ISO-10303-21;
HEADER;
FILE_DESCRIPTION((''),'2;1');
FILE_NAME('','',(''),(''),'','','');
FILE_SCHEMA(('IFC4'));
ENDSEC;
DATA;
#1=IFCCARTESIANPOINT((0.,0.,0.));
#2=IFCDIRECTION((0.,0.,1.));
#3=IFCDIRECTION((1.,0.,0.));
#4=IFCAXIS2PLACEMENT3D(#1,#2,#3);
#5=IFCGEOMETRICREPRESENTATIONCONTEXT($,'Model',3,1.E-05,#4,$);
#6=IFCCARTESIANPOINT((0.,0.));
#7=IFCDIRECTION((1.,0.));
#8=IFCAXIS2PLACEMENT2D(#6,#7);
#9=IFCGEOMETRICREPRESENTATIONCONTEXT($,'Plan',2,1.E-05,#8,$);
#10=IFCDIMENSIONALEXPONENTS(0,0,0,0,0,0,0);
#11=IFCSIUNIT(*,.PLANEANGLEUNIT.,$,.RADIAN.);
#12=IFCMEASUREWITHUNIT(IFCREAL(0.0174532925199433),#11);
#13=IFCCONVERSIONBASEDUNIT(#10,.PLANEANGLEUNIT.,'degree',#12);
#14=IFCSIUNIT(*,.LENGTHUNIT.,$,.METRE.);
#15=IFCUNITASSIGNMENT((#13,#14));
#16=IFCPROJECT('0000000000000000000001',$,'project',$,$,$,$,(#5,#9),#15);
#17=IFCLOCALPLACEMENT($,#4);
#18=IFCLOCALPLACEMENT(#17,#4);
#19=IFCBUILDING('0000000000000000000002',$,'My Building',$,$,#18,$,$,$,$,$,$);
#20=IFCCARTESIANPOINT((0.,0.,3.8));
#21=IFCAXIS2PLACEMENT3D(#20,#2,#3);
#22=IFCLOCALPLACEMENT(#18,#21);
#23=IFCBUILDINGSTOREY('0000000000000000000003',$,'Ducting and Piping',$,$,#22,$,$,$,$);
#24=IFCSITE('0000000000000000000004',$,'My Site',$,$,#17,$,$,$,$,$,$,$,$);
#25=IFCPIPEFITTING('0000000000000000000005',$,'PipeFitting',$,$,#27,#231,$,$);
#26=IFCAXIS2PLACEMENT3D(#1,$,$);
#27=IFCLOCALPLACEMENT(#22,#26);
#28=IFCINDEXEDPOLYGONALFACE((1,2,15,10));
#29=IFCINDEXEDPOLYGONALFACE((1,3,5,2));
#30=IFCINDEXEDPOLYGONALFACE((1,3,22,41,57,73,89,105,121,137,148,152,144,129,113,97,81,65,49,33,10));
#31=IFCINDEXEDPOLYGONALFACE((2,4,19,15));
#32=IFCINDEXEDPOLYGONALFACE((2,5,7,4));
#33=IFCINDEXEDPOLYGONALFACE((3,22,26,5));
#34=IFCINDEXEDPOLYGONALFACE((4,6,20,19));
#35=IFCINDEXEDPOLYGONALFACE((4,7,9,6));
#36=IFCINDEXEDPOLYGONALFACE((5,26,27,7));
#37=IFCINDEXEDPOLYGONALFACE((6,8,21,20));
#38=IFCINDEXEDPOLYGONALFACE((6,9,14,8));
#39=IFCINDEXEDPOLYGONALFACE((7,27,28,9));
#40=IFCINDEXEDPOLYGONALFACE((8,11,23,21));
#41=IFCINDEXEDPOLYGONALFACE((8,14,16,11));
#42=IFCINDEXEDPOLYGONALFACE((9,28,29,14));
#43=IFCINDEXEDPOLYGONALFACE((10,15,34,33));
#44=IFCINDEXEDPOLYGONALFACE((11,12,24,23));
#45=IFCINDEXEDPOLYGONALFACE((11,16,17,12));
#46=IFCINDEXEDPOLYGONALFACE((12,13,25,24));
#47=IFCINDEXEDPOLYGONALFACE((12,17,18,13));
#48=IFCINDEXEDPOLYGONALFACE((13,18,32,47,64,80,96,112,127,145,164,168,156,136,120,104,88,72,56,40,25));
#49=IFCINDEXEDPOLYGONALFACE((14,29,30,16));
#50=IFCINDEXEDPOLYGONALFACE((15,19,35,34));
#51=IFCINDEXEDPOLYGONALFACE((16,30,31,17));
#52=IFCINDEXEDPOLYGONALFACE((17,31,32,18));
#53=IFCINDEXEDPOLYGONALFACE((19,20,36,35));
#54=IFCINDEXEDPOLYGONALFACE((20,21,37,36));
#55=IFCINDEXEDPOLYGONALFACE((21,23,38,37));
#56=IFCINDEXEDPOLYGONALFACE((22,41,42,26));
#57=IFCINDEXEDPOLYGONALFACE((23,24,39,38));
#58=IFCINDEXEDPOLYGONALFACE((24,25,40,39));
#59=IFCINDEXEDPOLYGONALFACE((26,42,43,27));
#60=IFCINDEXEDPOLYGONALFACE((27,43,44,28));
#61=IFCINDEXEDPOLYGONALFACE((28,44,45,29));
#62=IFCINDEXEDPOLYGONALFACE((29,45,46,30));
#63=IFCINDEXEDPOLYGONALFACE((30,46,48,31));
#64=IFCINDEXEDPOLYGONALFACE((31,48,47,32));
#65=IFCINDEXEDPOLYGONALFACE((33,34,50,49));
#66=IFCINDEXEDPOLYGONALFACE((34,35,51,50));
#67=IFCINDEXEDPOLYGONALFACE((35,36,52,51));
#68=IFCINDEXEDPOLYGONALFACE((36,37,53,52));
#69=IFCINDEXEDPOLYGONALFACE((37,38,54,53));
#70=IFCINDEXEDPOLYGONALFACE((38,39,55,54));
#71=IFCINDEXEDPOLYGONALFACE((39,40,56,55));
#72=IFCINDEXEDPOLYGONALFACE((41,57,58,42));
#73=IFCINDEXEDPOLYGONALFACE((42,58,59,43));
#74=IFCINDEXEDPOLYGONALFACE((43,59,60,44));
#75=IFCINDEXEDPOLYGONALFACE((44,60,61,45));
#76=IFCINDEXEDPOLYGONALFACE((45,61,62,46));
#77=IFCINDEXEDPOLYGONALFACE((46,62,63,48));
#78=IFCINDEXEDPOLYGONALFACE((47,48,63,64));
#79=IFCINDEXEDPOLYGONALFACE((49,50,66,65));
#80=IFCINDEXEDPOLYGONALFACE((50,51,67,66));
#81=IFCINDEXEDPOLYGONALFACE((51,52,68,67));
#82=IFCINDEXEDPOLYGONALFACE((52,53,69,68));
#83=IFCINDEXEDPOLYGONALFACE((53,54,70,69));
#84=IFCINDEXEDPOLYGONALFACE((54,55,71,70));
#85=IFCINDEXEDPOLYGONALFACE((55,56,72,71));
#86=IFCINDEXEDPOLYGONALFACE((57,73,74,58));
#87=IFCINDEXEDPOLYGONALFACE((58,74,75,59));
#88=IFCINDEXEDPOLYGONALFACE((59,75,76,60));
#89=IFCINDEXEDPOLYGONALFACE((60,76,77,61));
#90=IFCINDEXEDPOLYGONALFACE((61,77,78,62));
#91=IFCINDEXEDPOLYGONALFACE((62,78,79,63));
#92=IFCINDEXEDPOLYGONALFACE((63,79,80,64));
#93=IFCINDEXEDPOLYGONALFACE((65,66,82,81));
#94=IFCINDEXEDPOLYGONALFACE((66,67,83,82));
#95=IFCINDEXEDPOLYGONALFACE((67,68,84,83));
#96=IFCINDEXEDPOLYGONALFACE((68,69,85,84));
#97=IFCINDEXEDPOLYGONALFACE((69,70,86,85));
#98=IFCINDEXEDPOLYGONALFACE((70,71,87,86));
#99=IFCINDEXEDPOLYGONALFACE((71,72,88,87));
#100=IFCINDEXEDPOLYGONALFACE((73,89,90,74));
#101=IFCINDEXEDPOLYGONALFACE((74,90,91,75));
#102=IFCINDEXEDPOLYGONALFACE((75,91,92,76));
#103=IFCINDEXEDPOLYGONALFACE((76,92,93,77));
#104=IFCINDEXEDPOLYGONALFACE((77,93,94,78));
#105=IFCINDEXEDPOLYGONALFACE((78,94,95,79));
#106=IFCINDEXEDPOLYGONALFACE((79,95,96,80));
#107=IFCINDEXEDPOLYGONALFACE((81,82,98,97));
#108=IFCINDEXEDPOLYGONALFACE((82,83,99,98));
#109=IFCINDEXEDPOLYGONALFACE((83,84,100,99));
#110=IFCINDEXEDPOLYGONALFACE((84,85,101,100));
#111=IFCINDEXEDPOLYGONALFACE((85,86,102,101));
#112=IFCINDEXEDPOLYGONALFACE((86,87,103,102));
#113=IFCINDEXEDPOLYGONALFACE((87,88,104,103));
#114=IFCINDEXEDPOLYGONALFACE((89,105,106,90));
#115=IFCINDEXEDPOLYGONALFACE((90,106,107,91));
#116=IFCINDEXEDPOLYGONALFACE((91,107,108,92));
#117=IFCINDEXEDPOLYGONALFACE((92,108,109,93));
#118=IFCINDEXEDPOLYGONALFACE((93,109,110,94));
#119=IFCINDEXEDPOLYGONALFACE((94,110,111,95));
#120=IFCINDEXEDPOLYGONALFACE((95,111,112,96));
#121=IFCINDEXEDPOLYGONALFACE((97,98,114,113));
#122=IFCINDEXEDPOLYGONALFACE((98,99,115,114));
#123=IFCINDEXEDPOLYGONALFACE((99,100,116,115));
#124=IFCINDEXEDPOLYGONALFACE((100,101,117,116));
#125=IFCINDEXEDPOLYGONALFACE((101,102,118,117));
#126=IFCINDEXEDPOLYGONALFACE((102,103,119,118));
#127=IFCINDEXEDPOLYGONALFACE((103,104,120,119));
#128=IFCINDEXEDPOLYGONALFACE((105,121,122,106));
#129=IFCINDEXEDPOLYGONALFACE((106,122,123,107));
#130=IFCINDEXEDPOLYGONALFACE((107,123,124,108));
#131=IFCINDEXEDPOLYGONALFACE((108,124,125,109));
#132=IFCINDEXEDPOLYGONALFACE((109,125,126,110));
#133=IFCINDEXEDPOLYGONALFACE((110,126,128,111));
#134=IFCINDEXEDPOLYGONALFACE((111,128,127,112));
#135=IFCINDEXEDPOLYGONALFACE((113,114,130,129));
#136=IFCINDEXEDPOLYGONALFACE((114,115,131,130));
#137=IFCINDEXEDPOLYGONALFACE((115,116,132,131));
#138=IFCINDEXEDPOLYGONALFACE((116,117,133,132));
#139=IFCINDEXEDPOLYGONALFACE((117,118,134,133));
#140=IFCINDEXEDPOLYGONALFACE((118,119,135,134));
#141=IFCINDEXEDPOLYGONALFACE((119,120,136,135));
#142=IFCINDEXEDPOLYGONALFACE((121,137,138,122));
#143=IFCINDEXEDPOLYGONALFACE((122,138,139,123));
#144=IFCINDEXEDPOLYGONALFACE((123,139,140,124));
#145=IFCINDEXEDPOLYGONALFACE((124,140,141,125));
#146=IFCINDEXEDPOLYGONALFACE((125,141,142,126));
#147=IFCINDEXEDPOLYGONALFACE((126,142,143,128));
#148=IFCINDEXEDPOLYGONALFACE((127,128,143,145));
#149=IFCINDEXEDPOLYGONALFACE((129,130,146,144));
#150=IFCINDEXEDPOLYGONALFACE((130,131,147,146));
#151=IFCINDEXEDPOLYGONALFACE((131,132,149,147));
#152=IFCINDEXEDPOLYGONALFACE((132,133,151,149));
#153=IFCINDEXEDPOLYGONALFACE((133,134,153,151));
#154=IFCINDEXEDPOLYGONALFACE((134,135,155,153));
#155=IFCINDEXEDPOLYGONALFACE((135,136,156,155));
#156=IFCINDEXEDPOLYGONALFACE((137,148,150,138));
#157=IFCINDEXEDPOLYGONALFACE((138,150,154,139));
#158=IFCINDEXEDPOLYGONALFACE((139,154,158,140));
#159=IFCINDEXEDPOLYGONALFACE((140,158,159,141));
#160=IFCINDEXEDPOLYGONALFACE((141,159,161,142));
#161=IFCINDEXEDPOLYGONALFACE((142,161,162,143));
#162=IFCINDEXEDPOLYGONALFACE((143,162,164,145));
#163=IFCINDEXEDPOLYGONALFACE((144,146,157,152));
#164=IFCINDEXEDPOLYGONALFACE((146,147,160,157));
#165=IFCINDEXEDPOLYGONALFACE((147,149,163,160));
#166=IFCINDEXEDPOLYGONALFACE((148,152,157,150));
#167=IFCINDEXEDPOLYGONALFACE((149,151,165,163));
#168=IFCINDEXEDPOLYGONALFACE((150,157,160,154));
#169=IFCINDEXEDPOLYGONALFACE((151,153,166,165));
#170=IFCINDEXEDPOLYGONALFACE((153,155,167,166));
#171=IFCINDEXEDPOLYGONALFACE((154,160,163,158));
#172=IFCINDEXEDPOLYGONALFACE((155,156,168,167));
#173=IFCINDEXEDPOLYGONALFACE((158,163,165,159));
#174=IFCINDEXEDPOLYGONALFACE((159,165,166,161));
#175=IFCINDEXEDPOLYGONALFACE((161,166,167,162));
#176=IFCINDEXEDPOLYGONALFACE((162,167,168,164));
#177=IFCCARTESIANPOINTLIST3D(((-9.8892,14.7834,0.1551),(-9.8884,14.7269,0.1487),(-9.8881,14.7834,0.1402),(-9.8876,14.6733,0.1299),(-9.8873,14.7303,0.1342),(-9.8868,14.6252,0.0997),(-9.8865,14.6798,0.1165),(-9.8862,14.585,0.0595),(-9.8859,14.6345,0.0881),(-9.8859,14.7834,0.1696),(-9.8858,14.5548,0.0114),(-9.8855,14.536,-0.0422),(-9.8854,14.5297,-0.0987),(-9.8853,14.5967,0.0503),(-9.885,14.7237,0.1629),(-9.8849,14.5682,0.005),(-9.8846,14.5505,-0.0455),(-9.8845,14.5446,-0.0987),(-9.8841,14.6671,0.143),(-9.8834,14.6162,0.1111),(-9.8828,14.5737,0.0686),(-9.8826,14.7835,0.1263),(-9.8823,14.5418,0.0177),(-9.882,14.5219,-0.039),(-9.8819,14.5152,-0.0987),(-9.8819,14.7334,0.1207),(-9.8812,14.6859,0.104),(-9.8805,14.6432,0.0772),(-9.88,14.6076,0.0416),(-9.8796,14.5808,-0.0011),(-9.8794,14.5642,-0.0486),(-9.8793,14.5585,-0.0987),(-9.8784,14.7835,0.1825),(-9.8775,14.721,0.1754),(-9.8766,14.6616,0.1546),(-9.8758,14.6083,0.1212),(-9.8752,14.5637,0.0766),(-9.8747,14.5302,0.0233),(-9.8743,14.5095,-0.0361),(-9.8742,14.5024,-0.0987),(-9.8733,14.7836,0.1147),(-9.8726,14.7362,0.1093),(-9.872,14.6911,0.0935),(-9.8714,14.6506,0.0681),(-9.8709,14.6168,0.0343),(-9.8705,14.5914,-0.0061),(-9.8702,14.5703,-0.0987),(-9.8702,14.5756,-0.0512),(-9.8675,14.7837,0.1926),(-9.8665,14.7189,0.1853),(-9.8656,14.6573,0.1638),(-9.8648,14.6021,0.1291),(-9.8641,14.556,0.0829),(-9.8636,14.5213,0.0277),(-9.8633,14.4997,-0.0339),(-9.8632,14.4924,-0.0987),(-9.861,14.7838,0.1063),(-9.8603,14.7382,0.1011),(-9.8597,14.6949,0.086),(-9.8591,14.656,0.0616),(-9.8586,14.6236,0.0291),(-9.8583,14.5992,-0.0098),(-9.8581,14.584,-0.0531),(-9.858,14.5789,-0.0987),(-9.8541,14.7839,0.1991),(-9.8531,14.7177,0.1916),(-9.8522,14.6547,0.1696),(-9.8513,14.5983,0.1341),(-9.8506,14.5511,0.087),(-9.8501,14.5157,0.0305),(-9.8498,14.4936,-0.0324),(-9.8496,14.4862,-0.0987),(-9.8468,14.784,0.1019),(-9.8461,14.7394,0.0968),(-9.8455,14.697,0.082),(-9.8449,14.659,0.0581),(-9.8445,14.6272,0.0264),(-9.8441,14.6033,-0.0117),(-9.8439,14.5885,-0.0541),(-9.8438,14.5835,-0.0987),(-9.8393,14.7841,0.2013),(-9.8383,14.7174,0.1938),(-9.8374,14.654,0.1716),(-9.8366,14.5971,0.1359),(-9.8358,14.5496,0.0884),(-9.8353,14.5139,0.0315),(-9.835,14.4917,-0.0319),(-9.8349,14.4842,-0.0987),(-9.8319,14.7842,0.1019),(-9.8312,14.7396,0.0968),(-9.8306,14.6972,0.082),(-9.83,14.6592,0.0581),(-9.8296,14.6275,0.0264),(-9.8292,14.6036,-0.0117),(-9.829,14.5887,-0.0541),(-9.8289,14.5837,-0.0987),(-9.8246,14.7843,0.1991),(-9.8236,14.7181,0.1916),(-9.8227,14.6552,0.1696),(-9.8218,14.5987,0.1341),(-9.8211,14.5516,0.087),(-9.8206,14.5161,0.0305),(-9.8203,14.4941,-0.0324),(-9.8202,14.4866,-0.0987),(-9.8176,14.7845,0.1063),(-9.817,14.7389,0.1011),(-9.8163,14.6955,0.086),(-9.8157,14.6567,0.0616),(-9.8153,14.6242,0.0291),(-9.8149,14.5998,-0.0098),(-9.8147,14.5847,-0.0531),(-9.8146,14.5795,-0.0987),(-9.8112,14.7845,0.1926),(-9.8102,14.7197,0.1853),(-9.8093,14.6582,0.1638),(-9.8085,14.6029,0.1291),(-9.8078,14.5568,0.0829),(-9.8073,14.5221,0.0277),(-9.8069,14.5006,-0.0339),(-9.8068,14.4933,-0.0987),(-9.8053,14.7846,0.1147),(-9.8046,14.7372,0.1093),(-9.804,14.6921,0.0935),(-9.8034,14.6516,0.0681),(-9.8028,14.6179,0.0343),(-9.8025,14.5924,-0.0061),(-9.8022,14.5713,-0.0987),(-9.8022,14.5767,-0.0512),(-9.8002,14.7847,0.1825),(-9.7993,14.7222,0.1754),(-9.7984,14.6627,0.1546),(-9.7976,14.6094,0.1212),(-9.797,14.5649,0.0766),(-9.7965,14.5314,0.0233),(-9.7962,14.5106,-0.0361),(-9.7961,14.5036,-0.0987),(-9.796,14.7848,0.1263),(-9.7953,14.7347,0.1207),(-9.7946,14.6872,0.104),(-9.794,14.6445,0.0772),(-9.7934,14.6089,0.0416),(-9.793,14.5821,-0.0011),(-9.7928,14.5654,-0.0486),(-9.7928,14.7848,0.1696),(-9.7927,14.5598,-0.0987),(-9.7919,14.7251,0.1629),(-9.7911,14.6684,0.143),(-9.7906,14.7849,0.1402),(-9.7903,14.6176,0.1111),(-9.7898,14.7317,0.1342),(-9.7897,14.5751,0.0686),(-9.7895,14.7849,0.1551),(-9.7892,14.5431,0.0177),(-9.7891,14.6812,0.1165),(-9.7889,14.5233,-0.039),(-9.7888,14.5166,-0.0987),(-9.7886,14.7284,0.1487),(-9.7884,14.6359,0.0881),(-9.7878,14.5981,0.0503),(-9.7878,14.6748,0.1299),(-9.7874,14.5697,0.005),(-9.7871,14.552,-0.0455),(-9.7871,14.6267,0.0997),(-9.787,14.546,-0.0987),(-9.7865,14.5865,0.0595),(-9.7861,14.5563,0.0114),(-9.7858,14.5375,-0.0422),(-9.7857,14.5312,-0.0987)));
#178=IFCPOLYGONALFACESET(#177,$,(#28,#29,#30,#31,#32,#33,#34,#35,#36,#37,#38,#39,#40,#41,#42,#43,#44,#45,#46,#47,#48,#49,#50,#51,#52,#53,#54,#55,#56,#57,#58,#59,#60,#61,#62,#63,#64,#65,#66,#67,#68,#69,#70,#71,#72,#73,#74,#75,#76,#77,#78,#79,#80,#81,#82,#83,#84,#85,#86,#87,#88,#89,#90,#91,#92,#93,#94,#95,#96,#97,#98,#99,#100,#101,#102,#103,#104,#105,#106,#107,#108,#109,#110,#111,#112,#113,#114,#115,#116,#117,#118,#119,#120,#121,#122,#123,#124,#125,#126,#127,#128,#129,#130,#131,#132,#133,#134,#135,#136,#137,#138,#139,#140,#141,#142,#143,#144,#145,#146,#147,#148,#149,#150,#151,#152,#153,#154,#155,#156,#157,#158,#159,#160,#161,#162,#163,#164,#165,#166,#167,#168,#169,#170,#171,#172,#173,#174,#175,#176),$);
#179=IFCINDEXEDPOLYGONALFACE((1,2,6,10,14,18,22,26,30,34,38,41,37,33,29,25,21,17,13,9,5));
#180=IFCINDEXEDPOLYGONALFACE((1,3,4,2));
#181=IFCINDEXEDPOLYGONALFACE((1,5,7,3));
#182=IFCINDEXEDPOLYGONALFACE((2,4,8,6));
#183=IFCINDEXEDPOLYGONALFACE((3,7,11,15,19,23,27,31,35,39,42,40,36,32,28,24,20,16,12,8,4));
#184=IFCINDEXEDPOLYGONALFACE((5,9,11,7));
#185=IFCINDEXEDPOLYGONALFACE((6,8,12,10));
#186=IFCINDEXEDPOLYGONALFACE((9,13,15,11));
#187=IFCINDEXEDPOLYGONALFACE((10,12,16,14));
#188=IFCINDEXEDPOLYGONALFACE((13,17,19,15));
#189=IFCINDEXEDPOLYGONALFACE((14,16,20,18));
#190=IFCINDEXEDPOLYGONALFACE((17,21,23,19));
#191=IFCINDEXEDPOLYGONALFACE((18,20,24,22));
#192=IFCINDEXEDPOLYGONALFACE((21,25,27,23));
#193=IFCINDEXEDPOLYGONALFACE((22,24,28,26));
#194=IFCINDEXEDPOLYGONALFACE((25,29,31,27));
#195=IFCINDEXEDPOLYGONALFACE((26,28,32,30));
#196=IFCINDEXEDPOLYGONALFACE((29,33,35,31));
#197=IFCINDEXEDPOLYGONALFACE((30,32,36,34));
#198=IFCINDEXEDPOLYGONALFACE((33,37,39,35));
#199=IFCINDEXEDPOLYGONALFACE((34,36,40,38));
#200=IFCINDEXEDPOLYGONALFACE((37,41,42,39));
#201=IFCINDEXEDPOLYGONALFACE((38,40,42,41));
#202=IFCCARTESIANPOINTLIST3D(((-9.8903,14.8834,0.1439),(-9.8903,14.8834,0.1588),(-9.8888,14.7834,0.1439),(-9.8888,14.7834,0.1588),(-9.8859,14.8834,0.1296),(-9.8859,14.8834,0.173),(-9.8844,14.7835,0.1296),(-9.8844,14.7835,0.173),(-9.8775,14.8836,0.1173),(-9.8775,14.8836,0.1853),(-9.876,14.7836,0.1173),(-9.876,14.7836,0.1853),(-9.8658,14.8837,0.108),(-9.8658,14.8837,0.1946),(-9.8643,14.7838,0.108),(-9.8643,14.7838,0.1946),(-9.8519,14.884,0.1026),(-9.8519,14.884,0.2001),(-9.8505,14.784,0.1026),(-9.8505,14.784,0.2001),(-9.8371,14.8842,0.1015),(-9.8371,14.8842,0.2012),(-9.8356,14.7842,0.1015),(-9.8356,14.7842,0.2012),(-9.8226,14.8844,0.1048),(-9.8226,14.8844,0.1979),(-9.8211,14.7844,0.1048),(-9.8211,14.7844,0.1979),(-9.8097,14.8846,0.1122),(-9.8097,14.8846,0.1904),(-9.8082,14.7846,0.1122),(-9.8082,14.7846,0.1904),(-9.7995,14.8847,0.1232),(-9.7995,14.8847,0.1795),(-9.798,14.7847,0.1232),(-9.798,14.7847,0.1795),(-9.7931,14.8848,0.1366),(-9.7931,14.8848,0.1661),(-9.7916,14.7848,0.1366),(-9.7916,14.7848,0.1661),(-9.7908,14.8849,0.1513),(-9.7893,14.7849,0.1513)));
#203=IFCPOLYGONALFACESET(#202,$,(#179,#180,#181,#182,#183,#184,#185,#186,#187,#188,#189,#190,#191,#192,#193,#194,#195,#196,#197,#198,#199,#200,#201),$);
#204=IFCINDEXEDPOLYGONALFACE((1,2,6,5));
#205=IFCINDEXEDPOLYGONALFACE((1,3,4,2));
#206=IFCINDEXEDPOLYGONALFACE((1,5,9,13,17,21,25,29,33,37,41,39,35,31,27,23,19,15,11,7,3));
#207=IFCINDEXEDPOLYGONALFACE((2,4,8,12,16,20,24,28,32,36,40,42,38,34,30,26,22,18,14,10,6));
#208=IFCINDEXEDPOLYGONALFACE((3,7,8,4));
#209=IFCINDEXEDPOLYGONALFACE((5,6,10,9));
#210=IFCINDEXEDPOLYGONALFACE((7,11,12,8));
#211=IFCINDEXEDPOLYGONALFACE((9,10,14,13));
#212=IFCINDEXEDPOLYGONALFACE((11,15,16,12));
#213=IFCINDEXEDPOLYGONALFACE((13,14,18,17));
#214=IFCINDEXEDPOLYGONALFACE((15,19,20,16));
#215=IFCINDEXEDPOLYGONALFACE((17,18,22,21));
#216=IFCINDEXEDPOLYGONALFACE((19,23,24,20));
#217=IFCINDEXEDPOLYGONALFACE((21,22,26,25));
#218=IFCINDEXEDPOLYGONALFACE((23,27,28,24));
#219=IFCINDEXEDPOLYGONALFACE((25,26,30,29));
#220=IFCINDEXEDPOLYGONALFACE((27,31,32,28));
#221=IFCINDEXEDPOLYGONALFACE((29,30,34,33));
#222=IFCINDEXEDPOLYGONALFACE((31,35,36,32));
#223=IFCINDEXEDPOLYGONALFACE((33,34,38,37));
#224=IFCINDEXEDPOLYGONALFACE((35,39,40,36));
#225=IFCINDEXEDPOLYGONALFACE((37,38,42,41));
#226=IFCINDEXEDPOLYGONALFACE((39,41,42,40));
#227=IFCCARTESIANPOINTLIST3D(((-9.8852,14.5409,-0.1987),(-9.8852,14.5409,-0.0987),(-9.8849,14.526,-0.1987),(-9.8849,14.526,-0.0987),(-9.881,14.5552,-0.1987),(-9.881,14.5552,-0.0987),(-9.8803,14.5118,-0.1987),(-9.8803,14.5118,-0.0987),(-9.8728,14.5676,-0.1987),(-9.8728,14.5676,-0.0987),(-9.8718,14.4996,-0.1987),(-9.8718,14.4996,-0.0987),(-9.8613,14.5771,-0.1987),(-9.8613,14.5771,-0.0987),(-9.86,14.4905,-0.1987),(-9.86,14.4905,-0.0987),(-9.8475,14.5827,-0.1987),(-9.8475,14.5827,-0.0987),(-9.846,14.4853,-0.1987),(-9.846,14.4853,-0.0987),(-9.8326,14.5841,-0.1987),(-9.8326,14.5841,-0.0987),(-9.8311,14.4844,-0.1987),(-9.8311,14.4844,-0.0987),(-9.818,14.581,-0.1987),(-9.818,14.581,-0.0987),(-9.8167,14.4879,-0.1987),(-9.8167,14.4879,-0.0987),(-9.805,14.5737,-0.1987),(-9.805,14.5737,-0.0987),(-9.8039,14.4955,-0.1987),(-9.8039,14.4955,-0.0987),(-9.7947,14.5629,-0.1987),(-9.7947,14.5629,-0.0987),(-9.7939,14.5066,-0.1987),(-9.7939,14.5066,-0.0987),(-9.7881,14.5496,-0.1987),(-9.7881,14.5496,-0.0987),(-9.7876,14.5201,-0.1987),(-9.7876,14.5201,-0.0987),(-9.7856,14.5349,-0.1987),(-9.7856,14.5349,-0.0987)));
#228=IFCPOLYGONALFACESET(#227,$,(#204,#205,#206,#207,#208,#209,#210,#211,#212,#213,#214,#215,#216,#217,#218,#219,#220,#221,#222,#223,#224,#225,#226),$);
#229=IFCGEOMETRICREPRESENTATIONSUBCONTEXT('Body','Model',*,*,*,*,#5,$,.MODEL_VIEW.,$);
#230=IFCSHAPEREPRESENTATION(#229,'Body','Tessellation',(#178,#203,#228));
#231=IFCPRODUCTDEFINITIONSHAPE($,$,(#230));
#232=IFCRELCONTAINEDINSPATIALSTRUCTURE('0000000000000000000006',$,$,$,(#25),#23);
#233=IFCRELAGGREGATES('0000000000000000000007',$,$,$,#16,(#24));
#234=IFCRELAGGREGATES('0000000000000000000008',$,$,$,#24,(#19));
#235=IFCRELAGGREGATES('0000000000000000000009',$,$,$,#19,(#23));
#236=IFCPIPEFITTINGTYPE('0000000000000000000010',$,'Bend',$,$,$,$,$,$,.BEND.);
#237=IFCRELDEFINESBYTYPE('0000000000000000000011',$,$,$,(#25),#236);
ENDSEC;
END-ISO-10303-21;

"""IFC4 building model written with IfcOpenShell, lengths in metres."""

from ifc_helpers import new_model, entity, si_unit, converted_unit, frame, origin_with_axes, origin_2d_with_axis, place, context, subcontext, project, spatial, circle, extrude, source, transform, mapped, type_object, type_shapes, element, save


model = new_model("IFC4")

# Units and contexts
model_context = context("Model", 3, precision=1e-05, world=origin_with_axes())
plan_context = context("Plan", 2, precision=1e-05, world=origin_2d_with_axis())
body_context = subcontext(model_context, "Body", "Model", "MODEL_VIEW")
ifc_project = project(units=[converted_unit("PLANEANGLEUNIT", "degree", entity("IfcReal", 0.0174532925199433), si_unit("PLANEANGLEUNIT", "RADIAN"), dimensions=[0, 0, 0, 0, 0, 0, 0]), si_unit("LENGTHUNIT", "METRE")], contexts=[model_context, plan_context])

# Site, building, storey
site_placement = place(None, origin_with_axes())
site = spatial("IfcSite", under=ifc_project, at=site_placement, Name="My Site")
building_placement = place(site_placement, origin_with_axes())
building = spatial("IfcBuilding", under=site, at=building_placement, Name="My Building")
storey_placement = place(building_placement, frame((0.0, 0.0, 3.8), z_axis=(0.0, 0.0, 1.0), x_axis=(1.0, 0.0, 0.0)))
storey = spatial("IfcBuildingStorey", under=building, at=storey_placement, Name="Ducting and Piping")

# Pipe fitting
pipe_fitting_type = type_object("IfcPipeFittingType", Name="Bend", PredefinedType="BEND")
shared_shape = source(origin_with_axes(), body_context, "Body", "SolidModel", [
    entity("IfcSweptDiskSolid", entity("IfcIndexedPolyCurve", entity("IfcCartesianPointList3D", [[0.0, 0.0, 0.1], [0.0, -0.0732, 0.2768], [0.0, -0.25, 0.35]]), [entity("IfcArcIndex", [1, 2, 3])]), 0.05),
    extrude(circle(Radius=0.05), origin_with_axes(), (0.0, 0.0, 1.0), 0.1),
    extrude(circle(Radius=0.05), frame((0.0, -0.25, 0.35), z_axis=(0.0, -1.0, 0.0), x_axis=(1.0, 0.0, 0.0)), (0.0, 0.0, 1.0), 0.1),
])
type_shapes(pipe_fitting_type, [shared_shape])
for number, where, z_axis, x_axis, name in (
    (1, (-9.8408, 14.8841, 0.1513), (0.014879, -0.999889, 0.0), (0.999889, 0.014879, 0.0), "PipeFitting"),
):
    element("IfcPipeFitting", number, at=place(storey_placement, frame(where, z_axis=z_axis, x_axis=x_axis)), inside=storey, type_object=pipe_fitting_type, Name=name, context=body_context, shape_type="MappedRepresentation", body=[
        mapped(shared_shape, transform((0.0, 0.0, 0.0), x_axis=(1.0, 0.0, 0.0), y_axis=(0.0, 1.0, 0.0), z_axis=(0.0, 0.0, 1.0), scale=1.0)),
    ])

save(model, "model.ifc")
